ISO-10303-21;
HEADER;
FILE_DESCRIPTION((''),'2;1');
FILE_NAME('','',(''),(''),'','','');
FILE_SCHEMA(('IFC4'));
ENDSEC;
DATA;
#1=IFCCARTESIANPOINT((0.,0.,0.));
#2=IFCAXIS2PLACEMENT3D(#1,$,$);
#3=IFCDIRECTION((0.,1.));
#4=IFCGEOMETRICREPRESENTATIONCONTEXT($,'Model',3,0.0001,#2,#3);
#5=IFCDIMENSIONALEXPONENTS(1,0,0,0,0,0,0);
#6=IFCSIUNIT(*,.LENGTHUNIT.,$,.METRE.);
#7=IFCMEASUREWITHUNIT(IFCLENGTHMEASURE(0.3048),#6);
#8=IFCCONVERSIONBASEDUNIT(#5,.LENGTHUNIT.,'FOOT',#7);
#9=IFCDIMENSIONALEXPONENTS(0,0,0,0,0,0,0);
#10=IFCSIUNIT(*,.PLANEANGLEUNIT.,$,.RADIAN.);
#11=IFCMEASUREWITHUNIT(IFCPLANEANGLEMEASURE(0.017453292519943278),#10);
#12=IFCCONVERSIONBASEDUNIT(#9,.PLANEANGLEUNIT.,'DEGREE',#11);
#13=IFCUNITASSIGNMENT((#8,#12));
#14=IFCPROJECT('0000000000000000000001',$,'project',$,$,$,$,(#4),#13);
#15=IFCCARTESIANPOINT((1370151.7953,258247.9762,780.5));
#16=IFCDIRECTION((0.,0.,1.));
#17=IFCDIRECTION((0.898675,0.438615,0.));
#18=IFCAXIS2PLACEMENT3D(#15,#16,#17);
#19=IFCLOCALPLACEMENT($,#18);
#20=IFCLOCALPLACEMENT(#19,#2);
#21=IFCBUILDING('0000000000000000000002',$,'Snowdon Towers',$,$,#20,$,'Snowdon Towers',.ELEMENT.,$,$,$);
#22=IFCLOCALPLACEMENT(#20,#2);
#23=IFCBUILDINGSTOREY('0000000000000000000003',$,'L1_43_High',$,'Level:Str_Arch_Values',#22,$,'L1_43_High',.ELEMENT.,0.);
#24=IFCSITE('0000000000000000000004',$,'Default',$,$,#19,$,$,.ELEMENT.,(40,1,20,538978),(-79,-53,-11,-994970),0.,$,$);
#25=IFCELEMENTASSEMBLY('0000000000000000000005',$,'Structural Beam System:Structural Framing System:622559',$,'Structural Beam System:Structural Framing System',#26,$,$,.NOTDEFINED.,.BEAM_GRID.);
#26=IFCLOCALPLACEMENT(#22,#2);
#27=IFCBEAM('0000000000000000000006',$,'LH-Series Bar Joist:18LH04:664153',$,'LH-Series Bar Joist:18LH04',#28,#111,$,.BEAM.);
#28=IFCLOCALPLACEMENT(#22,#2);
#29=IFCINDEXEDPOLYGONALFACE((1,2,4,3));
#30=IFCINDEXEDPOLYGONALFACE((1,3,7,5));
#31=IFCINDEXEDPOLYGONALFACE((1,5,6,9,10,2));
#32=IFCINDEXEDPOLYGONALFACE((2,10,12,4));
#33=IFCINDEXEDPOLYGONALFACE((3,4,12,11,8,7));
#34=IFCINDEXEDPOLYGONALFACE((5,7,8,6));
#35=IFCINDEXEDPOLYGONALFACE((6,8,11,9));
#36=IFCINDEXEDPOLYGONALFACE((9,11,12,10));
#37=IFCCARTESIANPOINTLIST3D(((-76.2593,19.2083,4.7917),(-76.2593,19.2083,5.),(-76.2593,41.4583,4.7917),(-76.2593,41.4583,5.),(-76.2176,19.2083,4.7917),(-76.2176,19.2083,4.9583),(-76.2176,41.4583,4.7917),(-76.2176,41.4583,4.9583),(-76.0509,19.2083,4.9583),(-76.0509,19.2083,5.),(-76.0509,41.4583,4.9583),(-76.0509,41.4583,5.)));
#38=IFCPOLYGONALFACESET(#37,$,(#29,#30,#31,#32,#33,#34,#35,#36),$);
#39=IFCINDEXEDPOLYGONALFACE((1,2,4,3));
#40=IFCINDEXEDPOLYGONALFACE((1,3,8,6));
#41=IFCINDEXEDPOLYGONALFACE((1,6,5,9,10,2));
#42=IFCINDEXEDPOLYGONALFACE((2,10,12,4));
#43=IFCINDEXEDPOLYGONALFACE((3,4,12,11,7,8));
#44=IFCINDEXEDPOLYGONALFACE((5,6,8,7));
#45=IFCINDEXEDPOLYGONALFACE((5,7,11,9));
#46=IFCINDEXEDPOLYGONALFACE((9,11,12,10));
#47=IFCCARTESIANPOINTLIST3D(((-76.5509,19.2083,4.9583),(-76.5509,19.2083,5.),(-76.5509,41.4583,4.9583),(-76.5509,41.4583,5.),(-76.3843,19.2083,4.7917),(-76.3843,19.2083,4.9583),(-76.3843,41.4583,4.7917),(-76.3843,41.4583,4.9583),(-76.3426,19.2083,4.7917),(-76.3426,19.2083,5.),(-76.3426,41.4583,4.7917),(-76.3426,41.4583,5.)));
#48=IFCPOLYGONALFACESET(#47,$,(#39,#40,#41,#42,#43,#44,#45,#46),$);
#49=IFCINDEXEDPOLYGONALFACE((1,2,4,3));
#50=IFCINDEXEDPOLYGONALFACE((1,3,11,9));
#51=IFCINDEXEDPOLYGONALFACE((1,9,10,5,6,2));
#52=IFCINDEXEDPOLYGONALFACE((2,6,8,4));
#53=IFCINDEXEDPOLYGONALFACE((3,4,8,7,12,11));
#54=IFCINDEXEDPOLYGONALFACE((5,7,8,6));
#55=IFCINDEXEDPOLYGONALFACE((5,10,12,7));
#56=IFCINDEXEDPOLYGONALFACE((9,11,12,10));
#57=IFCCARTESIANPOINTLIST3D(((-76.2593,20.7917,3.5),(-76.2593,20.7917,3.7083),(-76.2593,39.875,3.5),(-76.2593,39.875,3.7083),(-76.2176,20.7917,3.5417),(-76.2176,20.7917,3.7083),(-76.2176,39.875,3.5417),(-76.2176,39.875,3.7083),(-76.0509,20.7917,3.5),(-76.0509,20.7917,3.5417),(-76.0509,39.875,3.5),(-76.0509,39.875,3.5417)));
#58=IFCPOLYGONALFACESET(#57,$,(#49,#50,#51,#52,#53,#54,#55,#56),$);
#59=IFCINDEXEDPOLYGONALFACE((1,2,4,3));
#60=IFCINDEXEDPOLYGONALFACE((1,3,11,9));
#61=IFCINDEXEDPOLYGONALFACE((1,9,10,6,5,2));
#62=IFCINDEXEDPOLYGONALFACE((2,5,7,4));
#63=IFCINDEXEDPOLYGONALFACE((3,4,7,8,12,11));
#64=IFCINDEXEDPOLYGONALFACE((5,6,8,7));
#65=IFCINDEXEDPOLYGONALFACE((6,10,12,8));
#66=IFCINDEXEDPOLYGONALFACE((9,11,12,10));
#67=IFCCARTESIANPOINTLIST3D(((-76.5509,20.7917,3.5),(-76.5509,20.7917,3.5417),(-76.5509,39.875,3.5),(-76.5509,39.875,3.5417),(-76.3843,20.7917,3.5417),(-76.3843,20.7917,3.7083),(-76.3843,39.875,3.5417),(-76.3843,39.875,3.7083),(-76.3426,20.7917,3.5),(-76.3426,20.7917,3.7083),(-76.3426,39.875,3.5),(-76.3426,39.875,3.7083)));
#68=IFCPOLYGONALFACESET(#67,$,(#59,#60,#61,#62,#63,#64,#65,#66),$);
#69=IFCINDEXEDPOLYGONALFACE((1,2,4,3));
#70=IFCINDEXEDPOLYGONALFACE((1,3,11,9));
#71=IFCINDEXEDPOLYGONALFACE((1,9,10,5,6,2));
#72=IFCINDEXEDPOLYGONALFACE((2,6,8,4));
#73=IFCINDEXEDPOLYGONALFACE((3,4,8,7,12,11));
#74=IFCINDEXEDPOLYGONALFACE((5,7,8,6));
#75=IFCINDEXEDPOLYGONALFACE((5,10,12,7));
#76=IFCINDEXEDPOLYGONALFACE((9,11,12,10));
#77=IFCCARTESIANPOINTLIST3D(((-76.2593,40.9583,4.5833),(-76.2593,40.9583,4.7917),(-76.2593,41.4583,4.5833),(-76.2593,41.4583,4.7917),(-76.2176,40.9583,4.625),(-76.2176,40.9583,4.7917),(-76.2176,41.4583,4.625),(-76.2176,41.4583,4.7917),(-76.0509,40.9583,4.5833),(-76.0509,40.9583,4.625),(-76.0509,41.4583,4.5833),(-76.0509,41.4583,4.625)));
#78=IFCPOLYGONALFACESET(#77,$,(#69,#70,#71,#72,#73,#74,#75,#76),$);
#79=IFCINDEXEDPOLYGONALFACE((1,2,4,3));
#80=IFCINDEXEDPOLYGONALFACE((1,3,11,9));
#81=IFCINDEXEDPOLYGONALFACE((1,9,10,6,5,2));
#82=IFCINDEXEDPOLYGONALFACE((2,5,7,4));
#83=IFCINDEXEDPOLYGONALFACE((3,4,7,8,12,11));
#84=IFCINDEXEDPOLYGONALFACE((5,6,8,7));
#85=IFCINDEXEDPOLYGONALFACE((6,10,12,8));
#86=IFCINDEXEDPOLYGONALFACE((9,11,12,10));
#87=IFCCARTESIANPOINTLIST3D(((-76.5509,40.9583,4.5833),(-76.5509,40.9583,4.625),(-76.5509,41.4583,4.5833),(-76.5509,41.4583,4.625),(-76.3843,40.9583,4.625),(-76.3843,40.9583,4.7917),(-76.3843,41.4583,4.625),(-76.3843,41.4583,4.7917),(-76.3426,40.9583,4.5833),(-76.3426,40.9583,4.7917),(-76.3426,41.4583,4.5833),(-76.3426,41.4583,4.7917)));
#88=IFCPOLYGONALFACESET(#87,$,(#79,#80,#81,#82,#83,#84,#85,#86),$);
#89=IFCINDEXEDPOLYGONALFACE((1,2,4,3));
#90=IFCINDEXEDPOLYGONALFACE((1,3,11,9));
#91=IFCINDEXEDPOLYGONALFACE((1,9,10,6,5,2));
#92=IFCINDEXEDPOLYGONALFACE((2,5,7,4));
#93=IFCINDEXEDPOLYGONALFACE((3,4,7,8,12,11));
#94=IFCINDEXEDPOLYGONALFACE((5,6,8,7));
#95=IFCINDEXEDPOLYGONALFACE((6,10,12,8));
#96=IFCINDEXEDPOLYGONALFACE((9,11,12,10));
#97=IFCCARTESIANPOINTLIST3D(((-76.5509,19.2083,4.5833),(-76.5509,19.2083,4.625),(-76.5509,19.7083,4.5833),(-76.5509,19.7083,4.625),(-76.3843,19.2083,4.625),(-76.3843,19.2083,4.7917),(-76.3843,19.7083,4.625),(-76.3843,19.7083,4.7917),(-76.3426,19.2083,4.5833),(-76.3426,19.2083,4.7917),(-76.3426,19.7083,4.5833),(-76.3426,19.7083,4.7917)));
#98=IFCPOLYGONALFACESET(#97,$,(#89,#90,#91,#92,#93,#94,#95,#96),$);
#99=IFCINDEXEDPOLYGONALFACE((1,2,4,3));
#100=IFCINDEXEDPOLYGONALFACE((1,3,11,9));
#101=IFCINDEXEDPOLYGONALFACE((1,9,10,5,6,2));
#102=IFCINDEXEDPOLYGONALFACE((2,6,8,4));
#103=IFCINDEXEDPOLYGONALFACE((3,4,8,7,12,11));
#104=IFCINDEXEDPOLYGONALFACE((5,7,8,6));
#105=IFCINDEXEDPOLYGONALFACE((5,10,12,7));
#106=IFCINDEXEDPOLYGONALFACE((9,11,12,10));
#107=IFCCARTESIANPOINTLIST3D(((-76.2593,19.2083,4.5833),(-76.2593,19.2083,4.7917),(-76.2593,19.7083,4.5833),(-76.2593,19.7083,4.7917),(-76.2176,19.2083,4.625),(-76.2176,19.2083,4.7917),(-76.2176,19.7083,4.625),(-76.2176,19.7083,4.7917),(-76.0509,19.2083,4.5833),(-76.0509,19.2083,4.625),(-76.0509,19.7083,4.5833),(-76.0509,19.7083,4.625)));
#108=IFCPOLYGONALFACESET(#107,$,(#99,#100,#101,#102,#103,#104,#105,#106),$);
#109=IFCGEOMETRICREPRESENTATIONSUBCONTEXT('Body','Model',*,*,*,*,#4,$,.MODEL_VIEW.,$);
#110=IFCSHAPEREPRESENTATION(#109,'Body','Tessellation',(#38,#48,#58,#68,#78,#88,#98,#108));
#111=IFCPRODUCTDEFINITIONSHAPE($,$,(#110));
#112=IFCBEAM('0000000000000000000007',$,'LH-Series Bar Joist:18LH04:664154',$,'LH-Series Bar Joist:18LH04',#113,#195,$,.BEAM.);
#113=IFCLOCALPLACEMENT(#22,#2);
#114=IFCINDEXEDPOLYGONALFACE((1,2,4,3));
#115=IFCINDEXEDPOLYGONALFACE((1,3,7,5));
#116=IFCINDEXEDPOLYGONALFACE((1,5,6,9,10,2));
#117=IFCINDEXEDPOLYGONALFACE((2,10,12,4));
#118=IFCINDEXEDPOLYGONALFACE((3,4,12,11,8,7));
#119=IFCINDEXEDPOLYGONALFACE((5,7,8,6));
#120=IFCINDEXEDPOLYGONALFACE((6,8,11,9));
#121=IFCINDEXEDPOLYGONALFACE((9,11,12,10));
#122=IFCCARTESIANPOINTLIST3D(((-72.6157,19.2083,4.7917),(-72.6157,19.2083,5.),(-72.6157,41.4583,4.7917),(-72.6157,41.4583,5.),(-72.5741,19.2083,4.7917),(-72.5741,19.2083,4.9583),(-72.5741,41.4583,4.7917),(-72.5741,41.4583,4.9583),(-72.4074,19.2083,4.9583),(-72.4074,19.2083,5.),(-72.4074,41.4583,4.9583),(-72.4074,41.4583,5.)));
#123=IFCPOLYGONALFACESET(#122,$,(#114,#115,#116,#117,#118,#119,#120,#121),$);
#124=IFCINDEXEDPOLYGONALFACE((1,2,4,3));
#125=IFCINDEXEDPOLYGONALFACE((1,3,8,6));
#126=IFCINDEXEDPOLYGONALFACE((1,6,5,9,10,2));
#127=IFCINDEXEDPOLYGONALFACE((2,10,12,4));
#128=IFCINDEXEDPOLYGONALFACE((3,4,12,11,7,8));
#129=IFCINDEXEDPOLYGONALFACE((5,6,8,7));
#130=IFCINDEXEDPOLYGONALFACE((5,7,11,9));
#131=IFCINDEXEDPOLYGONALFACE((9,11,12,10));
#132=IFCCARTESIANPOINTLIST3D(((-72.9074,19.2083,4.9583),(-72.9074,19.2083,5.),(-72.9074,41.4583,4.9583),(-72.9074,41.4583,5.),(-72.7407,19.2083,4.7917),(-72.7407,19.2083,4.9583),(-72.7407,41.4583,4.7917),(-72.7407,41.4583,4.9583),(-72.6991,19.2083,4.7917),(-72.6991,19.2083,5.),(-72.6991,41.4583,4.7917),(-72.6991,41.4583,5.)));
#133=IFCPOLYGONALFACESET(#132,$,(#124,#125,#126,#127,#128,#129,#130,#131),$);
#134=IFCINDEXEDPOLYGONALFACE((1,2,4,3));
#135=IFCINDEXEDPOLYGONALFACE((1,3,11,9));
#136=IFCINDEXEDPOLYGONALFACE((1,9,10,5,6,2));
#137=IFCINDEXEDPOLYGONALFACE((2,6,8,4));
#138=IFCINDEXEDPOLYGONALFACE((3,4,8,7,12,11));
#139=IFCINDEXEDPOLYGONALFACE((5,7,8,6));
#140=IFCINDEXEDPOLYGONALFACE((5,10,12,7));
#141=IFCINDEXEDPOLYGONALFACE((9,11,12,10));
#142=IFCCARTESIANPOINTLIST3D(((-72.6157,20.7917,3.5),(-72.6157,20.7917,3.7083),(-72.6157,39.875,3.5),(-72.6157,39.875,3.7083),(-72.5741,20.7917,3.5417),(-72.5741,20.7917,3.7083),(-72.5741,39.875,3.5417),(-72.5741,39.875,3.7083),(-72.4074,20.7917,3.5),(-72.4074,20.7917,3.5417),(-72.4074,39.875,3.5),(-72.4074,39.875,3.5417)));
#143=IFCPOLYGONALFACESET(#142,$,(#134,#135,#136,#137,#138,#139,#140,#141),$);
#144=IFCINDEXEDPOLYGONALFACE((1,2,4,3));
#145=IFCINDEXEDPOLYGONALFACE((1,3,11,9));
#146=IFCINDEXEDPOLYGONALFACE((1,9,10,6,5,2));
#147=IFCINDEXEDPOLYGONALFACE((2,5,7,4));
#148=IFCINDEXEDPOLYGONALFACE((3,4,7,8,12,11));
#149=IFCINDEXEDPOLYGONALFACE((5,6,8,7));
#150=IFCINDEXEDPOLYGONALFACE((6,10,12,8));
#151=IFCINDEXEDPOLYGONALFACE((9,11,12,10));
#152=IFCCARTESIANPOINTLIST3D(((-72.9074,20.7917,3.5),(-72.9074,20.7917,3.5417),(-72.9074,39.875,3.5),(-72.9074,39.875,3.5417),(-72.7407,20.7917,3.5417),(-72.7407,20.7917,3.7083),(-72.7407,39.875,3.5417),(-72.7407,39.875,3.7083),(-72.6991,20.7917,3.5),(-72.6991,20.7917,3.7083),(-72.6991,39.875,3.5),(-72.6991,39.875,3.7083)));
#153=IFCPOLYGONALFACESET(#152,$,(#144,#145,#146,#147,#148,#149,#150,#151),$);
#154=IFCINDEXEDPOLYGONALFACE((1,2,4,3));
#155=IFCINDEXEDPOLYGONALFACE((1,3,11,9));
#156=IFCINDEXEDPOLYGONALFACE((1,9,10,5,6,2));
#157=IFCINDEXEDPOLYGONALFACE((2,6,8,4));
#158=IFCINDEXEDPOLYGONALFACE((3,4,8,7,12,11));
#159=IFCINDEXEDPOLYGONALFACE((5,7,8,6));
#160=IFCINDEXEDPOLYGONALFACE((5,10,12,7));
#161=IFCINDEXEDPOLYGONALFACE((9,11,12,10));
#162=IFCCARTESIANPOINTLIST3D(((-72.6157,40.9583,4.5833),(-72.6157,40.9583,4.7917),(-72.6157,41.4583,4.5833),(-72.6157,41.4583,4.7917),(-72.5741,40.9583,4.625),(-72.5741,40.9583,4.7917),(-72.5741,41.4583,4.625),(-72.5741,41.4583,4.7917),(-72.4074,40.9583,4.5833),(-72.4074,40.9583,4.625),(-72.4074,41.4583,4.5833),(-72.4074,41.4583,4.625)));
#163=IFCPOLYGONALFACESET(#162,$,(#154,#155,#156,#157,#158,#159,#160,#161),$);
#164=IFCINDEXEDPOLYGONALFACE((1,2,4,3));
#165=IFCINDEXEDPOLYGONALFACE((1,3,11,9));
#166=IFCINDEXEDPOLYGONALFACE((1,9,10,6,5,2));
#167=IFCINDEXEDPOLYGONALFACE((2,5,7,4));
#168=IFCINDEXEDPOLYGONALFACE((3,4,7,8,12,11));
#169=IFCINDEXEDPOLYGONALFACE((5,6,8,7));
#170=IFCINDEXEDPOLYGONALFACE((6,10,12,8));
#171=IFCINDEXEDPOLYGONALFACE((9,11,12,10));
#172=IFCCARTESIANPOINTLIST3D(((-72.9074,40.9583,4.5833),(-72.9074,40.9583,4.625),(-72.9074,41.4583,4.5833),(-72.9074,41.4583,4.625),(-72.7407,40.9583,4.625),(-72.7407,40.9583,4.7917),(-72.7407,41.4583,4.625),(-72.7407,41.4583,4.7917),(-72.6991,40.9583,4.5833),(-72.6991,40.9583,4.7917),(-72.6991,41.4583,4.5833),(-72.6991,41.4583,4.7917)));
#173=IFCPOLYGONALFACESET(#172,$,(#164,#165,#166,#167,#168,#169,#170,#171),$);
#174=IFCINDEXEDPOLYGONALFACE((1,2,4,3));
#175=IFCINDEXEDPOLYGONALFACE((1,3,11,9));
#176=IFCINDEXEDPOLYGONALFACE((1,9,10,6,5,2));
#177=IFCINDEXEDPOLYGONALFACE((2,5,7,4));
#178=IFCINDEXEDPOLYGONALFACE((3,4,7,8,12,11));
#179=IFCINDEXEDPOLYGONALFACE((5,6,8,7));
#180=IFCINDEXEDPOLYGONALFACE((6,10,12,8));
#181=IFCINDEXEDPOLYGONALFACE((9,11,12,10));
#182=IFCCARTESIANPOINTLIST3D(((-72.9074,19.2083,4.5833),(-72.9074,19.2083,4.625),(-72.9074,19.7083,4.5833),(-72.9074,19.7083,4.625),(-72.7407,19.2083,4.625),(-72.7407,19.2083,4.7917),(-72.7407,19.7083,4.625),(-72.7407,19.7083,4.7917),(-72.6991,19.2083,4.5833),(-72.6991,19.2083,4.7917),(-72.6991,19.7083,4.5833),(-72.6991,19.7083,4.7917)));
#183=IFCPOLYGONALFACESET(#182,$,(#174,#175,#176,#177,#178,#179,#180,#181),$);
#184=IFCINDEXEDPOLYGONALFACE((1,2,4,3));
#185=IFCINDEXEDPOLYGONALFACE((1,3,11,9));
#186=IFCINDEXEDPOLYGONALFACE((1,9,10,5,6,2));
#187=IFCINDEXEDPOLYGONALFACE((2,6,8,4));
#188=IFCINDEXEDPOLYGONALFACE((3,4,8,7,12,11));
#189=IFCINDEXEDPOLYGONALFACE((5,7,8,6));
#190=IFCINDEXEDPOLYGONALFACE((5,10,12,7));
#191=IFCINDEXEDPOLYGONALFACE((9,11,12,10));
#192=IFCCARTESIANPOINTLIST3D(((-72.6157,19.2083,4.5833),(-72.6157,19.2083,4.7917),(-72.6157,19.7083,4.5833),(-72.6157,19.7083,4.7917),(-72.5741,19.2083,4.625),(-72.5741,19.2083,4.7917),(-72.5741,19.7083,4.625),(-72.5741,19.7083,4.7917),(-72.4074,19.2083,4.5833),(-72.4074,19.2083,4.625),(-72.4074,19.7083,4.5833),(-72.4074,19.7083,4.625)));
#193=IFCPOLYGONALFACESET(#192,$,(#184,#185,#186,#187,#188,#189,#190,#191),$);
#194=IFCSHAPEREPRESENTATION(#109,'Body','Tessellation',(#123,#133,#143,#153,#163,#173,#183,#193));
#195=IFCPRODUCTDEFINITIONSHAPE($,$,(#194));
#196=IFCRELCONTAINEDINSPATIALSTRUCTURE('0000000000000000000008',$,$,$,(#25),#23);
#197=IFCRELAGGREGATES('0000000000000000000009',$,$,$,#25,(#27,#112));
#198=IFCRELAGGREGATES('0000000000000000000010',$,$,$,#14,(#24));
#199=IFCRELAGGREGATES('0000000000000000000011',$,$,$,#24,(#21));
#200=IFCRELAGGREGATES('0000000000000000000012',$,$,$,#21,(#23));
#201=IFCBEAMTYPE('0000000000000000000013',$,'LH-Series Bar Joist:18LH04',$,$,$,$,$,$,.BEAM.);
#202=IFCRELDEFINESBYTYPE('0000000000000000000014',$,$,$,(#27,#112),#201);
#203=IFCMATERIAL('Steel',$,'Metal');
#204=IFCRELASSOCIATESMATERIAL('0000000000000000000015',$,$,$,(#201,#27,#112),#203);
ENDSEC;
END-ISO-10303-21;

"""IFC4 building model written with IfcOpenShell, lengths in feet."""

from ifc_helpers import new_model, entity, si_unit, converted_unit, direction, frame, origin, place, context, subcontext, project, spatial, indexed_curve, outline, extrude, source, transform, mapped, material, type_object, type_shapes, element, aggregate, save


model = new_model("IFC4")

# Units and contexts
model_context = context("Model", 3, precision=0.0001, world=origin(), true_north=direction((0.0, 1.0)))
body_context = subcontext(model_context, "Body", "Model", "MODEL_VIEW")
ifc_project = project(units=[converted_unit("LENGTHUNIT", "FOOT", entity("IfcLengthMeasure", 0.3048), si_unit("LENGTHUNIT", "METRE"), dimensions=[1, 0, 0, 0, 0, 0, 0]), converted_unit("PLANEANGLEUNIT", "DEGREE", entity("IfcPlaneAngleMeasure", 0.017453292519943278), si_unit("PLANEANGLEUNIT", "RADIAN"), dimensions=[0, 0, 0, 0, 0, 0, 0])], contexts=[model_context])

# Site, building, storey
site_placement = place(None, frame((1370151.7953, 258247.9762, 780.5), z_axis=(0.0, 0.0, 1.0), x_axis=(0.898675, 0.438615, 0.0)))
site = spatial("IfcSite", under=ifc_project, at=site_placement, Name="Default", CompositionType="ELEMENT", RefLatitude=(40, 1, 20, 538978), RefLongitude=(-79, -53, -11, -994970), RefElevation=0.0)
building_placement = place(site_placement, origin())
building = spatial("IfcBuilding", under=site, at=building_placement, Name="Snowdon Towers", LongName="Snowdon Towers", CompositionType="ELEMENT")
storey_placement = place(building_placement, origin())
storey = spatial("IfcBuildingStorey", under=building, at=storey_placement, Name="L1_43_High", ObjectType="Level:Str_Arch_Values", LongName="L1_43_High", CompositionType="ELEMENT", Elevation=0.0)

# Shared definitions
ifc_material_1 = material(Name="Steel", Category="Metal")

# Element assembly, beams
assembly_placement = place(storey_placement, origin())
assembly = element("IfcElementAssembly", 1, at=assembly_placement, inside=storey, Name="Structural Beam System:Structural Framing System:622559", ObjectType="Structural Beam System:Structural Framing System", AssemblyPlace="NOTDEFINED", PredefinedType="BEAM_GRID")
beam_type_1 = type_object("IfcBeamType", Name="LH-Series Bar Joist:18LH04", PredefinedType="BEAM", material=ifc_material_1)
shared_shape_1 = source(origin(), body_context, "Body", "SweptSolid", [
    extrude(outline(indexed_curve([(-0.0833, -0.0833), (0.125, -0.0833), (0.125, -0.0417), (-0.0417, -0.0417), (-0.0417, 0.125), (-0.0833, 0.125), (-0.0833, -0.0833)], self_intersect=False)), frame((-11.125, -0.125, 0.6667), z_axis=(1.0, 0.0, 0.0), x_axis=(0.0, -1.0, 0.0)), (0.0, 0.0, 1.0), 22.25),
    extrude(outline(indexed_curve([(-0.0833, -0.0833), (0.125, -0.0833), (0.125, -0.0417), (-0.0417, -0.0417), (-0.0417, 0.125), (-0.0833, 0.125), (-0.0833, -0.0833)], self_intersect=False)), frame((-11.125, 0.125, 0.6667), z_axis=(1.0, 0.0, 0.0), x_axis=(0.0, 0.0, -1.0)), (0.0, 0.0, 1.0), 22.25),
    extrude(outline(indexed_curve([(-0.0833, -0.0833), (0.125, -0.0833), (0.125, -0.0417), (-0.0417, -0.0417), (-0.0417, 0.125), (-0.0833, 0.125), (-0.0833, -0.0833)], self_intersect=False)), frame((-9.5417, -0.125, -0.6667), z_axis=(1.0, 0.0, 0.0), x_axis=(0.0, 0.0, 1.0)), (0.0, 0.0, 1.0), 19.0833),
    extrude(outline(indexed_curve([(-0.0833, -0.0833), (0.125, -0.0833), (0.125, -0.0417), (-0.0417, -0.0417), (-0.0417, 0.125), (-0.0833, 0.125), (-0.0833, -0.0833)], self_intersect=False)), frame((-9.5417, 0.125, -0.6667), z_axis=(1.0, 0.0, 0.0), x_axis=(0.0, 1.0, 0.0)), (0.0, 0.0, 1.0), 19.0833),
    extrude(outline(indexed_curve([(-0.0833, -0.0833), (0.125, -0.0833), (0.125, -0.0417), (-0.0417, -0.0417), (-0.0417, 0.125), (-0.0833, 0.125), (-0.0833, -0.0833)], self_intersect=False)), frame((10.625, -0.125, 0.4167), z_axis=(1.0, 0.0, 0.0), x_axis=(0.0, 0.0, 1.0)), (0.0, 0.0, 1.0), 0.5),
    extrude(outline(indexed_curve([(-0.0833, -0.0833), (0.125, -0.0833), (0.125, -0.0417), (-0.0417, -0.0417), (-0.0417, 0.125), (-0.0833, 0.125), (-0.0833, -0.0833)], self_intersect=False)), frame((10.625, 0.125, 0.4167), z_axis=(1.0, 0.0, 0.0), x_axis=(0.0, 1.0, 0.0)), (0.0, 0.0, 1.0), 0.5),
    extrude(outline(indexed_curve([(-0.0833, -0.125), (-0.0417, -0.125), (-0.0417, 0.0417), (0.125, 0.0417), (0.125, 0.0833), (-0.0833, 0.0833), (-0.0833, -0.125)], self_intersect=False)), frame((-11.125, 0.125, 0.4167), z_axis=(1.0, 0.0, 0.0), x_axis=(0.0, 0.0, 1.0)), (0.0, 0.0, 1.0), 0.5),
    extrude(outline(indexed_curve([(-0.0833, -0.0833), (0.125, -0.0833), (0.125, -0.0417), (-0.0417, -0.0417), (-0.0417, 0.125), (-0.0833, 0.125), (-0.0833, -0.0833)], self_intersect=False)), frame((-11.125, -0.125, 0.4167), z_axis=(1.0, 0.0, 0.0), x_axis=(0.0, 0.0, 1.0)), (0.0, 0.0, 1.0), 0.5),
])
type_shapes(beam_type_1, [shared_shape_1])
beam_1_placement = place(assembly_placement, frame((-76.3009, 30.3333, 4.25), z_axis=(0.0, 0.0, 1.0), x_axis=(0.0, 1.0, 0.0)))
beam_1 = element("IfcBeam", 2, at=beam_1_placement, type_object=beam_type_1, material=ifc_material_1, Name="LH-Series Bar Joist:18LH04:664153", ObjectType="LH-Series Bar Joist:18LH04", PredefinedType="BEAM", context=body_context, shape_type="MappedRepresentation", body=[
    mapped(shared_shape_1, transform((0.0, 0.0, 0.0), scale=1.0)),
])
beam_2_placement = place(assembly_placement, frame((-72.6574, 30.3333, 4.25), z_axis=(0.0, 0.0, 1.0), x_axis=(0.0, 1.0, 0.0)))
beam_2 = element("IfcBeam", 3, at=beam_2_placement, type_object=beam_type_1, material=ifc_material_1, Name="LH-Series Bar Joist:18LH04:664154", ObjectType="LH-Series Bar Joist:18LH04", PredefinedType="BEAM", context=body_context, shape_type="MappedRepresentation", body=[
    mapped(shared_shape_1, transform((0.0, 0.0, 0.0), scale=1.0)),
])
aggregate(assembly, [beam_1, beam_2])

save(model, "model.ifc")
